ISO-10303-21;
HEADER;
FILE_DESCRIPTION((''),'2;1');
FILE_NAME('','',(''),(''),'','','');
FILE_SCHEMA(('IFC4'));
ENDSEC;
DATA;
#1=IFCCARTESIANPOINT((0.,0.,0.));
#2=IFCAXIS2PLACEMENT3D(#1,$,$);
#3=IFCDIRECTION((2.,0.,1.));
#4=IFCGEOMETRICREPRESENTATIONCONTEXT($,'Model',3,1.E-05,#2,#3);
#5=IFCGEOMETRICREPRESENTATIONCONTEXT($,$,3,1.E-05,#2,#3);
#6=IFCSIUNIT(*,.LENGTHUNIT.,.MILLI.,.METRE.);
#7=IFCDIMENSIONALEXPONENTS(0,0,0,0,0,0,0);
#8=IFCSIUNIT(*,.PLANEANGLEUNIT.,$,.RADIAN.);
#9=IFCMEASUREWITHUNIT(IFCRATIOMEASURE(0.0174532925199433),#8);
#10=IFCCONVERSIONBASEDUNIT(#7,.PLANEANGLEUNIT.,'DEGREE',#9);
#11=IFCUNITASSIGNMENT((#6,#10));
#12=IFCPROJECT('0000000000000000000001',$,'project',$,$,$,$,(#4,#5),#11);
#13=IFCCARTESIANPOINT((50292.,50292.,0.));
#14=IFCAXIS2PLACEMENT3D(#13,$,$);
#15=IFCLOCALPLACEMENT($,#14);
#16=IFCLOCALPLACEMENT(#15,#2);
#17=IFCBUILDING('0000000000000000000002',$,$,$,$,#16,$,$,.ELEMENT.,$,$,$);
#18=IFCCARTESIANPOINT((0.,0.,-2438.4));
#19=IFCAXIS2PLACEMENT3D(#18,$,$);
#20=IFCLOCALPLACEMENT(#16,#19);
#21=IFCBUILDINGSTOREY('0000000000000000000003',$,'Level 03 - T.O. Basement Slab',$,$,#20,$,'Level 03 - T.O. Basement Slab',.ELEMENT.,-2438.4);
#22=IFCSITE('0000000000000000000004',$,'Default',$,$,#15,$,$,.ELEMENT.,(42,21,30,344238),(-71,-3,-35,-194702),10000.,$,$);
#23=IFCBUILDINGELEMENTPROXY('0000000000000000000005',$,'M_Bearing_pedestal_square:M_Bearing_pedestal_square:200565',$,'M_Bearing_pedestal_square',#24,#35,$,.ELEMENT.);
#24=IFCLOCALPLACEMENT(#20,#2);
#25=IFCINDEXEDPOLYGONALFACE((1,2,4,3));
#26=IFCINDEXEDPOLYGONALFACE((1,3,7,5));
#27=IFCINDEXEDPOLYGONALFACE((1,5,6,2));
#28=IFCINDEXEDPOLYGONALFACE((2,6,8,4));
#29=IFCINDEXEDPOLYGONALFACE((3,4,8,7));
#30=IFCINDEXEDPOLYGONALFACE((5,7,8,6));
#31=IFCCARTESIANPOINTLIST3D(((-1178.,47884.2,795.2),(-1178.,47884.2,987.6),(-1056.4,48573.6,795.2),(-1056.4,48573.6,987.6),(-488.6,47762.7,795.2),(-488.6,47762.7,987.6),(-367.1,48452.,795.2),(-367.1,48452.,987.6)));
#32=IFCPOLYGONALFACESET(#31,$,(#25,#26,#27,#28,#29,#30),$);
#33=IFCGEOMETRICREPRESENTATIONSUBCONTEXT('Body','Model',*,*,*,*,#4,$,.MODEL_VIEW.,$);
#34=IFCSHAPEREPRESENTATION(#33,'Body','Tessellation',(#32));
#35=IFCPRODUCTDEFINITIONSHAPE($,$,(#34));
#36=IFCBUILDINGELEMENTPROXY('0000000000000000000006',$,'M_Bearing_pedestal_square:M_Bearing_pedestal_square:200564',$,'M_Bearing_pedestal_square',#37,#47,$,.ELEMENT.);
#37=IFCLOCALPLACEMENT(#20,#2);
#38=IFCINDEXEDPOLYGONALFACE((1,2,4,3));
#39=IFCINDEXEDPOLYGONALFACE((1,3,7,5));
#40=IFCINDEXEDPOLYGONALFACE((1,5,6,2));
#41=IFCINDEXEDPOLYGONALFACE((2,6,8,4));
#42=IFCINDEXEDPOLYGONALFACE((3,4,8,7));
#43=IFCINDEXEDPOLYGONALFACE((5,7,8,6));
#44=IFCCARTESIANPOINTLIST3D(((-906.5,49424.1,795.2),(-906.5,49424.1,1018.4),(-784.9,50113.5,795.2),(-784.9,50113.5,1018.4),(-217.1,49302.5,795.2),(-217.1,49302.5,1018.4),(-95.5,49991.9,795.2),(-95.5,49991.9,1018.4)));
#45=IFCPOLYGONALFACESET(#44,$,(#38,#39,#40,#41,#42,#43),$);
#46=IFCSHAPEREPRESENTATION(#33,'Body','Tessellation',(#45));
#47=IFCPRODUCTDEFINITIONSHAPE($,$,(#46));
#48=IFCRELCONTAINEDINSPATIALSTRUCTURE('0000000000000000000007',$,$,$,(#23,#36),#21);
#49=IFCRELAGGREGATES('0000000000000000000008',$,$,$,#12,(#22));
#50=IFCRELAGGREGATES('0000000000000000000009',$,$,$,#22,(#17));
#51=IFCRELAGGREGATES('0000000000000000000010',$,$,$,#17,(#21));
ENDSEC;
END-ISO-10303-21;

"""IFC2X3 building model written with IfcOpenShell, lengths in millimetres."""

from ifc_helpers import new_model, entity, si_unit, converted_unit, direction, frame, origin, origin_2d_with_axis, place, context, subcontext, project, spatial, rectangle, extrude, source, transform, mapped, element, save


model = new_model("IFC2X3")

# Units and contexts
model_context = context("Model", 3, precision=1e-05, world=origin(), true_north=direction((2.0, 0.0, 1.0)))
context_of_model = context(None, 3, precision=1e-05, world=origin(), true_north=direction((2.0, 0.0, 1.0)))
body_context = subcontext(model_context, "Body", "Model", "MODEL_VIEW")
ifc_project = project(units=[si_unit("LENGTHUNIT", "METRE", prefix="MILLI"), converted_unit("PLANEANGLEUNIT", "DEGREE", entity("IfcRatioMeasure", 0.0174532925199433), si_unit("PLANEANGLEUNIT", "RADIAN"), dimensions=[0, 0, 0, 0, 0, 0, 0])], contexts=[model_context, context_of_model])

# Site, building, storey
site_placement = place(None, frame((50292.0, 50292.0, 0.0)))
site = spatial("IfcSite", under=ifc_project, at=site_placement, Name="Default", CompositionType="ELEMENT", RefLatitude=(42, 21, 30, 344238), RefLongitude=(-71, -3, -35, -194702), RefElevation=10000.0)
building_placement = place(site_placement, origin())
building = spatial("IfcBuilding", under=site, at=building_placement, CompositionType="ELEMENT")
storey_placement = place(building_placement, frame((0.0, 0.0, -2438.4)))
storey = spatial("IfcBuildingStorey", under=building, at=storey_placement, Name="Level 03 - T.O. Basement Slab", LongName="Level 03 - T.O. Basement Slab", CompositionType="ELEMENT", Elevation=-2438.4)

# Building element proxies
shared_shape_1 = source(origin(), body_context, "Body", "SweptSolid", [
    extrude(rectangle(XDim=700.0, YDim=700.0, at=origin_2d_with_axis()), frame((0.0, 0.0, -192.4)), (0.0, 0.0, 1.0), 192.4),
])
proxy_1_placement = place(storey_placement, frame((-772.5, 48168.1, 987.6), z_axis=(0.0, 0.0, 1.0), x_axis=(0.173648, 0.984808, 0.0)))
element("IfcBuildingElementProxy", 1, at=proxy_1_placement, inside=storey, Name="M_Bearing_pedestal_square:M_Bearing_pedestal_square:200565", ObjectType="M_Bearing_pedestal_square", CompositionType="ELEMENT", context=body_context, shape_type="MappedRepresentation", body=[
    mapped(shared_shape_1, transform((0.0, 0.0, 0.0), scale=1.0)),
])
shared_shape_2 = source(origin(), body_context, "Body", "SweptSolid", [
    extrude(rectangle(XDim=700.0, YDim=700.0, at=origin_2d_with_axis()), frame((0.0, 0.0, -223.2)), (0.0, 0.0, 1.0), 223.2),
])
proxy_2_placement = place(storey_placement, frame((-501.0, 49708.0, 1018.4), z_axis=(0.0, 0.0, 1.0), x_axis=(0.173648, 0.984808, 0.0)))
element("IfcBuildingElementProxy", 2, at=proxy_2_placement, inside=storey, Name="M_Bearing_pedestal_square:M_Bearing_pedestal_square:200564", ObjectType="M_Bearing_pedestal_square", CompositionType="ELEMENT", context=body_context, shape_type="MappedRepresentation", body=[
    mapped(shared_shape_2, transform((0.0, 0.0, 0.0), scale=1.0)),
])

save(model, "model.ifc")
